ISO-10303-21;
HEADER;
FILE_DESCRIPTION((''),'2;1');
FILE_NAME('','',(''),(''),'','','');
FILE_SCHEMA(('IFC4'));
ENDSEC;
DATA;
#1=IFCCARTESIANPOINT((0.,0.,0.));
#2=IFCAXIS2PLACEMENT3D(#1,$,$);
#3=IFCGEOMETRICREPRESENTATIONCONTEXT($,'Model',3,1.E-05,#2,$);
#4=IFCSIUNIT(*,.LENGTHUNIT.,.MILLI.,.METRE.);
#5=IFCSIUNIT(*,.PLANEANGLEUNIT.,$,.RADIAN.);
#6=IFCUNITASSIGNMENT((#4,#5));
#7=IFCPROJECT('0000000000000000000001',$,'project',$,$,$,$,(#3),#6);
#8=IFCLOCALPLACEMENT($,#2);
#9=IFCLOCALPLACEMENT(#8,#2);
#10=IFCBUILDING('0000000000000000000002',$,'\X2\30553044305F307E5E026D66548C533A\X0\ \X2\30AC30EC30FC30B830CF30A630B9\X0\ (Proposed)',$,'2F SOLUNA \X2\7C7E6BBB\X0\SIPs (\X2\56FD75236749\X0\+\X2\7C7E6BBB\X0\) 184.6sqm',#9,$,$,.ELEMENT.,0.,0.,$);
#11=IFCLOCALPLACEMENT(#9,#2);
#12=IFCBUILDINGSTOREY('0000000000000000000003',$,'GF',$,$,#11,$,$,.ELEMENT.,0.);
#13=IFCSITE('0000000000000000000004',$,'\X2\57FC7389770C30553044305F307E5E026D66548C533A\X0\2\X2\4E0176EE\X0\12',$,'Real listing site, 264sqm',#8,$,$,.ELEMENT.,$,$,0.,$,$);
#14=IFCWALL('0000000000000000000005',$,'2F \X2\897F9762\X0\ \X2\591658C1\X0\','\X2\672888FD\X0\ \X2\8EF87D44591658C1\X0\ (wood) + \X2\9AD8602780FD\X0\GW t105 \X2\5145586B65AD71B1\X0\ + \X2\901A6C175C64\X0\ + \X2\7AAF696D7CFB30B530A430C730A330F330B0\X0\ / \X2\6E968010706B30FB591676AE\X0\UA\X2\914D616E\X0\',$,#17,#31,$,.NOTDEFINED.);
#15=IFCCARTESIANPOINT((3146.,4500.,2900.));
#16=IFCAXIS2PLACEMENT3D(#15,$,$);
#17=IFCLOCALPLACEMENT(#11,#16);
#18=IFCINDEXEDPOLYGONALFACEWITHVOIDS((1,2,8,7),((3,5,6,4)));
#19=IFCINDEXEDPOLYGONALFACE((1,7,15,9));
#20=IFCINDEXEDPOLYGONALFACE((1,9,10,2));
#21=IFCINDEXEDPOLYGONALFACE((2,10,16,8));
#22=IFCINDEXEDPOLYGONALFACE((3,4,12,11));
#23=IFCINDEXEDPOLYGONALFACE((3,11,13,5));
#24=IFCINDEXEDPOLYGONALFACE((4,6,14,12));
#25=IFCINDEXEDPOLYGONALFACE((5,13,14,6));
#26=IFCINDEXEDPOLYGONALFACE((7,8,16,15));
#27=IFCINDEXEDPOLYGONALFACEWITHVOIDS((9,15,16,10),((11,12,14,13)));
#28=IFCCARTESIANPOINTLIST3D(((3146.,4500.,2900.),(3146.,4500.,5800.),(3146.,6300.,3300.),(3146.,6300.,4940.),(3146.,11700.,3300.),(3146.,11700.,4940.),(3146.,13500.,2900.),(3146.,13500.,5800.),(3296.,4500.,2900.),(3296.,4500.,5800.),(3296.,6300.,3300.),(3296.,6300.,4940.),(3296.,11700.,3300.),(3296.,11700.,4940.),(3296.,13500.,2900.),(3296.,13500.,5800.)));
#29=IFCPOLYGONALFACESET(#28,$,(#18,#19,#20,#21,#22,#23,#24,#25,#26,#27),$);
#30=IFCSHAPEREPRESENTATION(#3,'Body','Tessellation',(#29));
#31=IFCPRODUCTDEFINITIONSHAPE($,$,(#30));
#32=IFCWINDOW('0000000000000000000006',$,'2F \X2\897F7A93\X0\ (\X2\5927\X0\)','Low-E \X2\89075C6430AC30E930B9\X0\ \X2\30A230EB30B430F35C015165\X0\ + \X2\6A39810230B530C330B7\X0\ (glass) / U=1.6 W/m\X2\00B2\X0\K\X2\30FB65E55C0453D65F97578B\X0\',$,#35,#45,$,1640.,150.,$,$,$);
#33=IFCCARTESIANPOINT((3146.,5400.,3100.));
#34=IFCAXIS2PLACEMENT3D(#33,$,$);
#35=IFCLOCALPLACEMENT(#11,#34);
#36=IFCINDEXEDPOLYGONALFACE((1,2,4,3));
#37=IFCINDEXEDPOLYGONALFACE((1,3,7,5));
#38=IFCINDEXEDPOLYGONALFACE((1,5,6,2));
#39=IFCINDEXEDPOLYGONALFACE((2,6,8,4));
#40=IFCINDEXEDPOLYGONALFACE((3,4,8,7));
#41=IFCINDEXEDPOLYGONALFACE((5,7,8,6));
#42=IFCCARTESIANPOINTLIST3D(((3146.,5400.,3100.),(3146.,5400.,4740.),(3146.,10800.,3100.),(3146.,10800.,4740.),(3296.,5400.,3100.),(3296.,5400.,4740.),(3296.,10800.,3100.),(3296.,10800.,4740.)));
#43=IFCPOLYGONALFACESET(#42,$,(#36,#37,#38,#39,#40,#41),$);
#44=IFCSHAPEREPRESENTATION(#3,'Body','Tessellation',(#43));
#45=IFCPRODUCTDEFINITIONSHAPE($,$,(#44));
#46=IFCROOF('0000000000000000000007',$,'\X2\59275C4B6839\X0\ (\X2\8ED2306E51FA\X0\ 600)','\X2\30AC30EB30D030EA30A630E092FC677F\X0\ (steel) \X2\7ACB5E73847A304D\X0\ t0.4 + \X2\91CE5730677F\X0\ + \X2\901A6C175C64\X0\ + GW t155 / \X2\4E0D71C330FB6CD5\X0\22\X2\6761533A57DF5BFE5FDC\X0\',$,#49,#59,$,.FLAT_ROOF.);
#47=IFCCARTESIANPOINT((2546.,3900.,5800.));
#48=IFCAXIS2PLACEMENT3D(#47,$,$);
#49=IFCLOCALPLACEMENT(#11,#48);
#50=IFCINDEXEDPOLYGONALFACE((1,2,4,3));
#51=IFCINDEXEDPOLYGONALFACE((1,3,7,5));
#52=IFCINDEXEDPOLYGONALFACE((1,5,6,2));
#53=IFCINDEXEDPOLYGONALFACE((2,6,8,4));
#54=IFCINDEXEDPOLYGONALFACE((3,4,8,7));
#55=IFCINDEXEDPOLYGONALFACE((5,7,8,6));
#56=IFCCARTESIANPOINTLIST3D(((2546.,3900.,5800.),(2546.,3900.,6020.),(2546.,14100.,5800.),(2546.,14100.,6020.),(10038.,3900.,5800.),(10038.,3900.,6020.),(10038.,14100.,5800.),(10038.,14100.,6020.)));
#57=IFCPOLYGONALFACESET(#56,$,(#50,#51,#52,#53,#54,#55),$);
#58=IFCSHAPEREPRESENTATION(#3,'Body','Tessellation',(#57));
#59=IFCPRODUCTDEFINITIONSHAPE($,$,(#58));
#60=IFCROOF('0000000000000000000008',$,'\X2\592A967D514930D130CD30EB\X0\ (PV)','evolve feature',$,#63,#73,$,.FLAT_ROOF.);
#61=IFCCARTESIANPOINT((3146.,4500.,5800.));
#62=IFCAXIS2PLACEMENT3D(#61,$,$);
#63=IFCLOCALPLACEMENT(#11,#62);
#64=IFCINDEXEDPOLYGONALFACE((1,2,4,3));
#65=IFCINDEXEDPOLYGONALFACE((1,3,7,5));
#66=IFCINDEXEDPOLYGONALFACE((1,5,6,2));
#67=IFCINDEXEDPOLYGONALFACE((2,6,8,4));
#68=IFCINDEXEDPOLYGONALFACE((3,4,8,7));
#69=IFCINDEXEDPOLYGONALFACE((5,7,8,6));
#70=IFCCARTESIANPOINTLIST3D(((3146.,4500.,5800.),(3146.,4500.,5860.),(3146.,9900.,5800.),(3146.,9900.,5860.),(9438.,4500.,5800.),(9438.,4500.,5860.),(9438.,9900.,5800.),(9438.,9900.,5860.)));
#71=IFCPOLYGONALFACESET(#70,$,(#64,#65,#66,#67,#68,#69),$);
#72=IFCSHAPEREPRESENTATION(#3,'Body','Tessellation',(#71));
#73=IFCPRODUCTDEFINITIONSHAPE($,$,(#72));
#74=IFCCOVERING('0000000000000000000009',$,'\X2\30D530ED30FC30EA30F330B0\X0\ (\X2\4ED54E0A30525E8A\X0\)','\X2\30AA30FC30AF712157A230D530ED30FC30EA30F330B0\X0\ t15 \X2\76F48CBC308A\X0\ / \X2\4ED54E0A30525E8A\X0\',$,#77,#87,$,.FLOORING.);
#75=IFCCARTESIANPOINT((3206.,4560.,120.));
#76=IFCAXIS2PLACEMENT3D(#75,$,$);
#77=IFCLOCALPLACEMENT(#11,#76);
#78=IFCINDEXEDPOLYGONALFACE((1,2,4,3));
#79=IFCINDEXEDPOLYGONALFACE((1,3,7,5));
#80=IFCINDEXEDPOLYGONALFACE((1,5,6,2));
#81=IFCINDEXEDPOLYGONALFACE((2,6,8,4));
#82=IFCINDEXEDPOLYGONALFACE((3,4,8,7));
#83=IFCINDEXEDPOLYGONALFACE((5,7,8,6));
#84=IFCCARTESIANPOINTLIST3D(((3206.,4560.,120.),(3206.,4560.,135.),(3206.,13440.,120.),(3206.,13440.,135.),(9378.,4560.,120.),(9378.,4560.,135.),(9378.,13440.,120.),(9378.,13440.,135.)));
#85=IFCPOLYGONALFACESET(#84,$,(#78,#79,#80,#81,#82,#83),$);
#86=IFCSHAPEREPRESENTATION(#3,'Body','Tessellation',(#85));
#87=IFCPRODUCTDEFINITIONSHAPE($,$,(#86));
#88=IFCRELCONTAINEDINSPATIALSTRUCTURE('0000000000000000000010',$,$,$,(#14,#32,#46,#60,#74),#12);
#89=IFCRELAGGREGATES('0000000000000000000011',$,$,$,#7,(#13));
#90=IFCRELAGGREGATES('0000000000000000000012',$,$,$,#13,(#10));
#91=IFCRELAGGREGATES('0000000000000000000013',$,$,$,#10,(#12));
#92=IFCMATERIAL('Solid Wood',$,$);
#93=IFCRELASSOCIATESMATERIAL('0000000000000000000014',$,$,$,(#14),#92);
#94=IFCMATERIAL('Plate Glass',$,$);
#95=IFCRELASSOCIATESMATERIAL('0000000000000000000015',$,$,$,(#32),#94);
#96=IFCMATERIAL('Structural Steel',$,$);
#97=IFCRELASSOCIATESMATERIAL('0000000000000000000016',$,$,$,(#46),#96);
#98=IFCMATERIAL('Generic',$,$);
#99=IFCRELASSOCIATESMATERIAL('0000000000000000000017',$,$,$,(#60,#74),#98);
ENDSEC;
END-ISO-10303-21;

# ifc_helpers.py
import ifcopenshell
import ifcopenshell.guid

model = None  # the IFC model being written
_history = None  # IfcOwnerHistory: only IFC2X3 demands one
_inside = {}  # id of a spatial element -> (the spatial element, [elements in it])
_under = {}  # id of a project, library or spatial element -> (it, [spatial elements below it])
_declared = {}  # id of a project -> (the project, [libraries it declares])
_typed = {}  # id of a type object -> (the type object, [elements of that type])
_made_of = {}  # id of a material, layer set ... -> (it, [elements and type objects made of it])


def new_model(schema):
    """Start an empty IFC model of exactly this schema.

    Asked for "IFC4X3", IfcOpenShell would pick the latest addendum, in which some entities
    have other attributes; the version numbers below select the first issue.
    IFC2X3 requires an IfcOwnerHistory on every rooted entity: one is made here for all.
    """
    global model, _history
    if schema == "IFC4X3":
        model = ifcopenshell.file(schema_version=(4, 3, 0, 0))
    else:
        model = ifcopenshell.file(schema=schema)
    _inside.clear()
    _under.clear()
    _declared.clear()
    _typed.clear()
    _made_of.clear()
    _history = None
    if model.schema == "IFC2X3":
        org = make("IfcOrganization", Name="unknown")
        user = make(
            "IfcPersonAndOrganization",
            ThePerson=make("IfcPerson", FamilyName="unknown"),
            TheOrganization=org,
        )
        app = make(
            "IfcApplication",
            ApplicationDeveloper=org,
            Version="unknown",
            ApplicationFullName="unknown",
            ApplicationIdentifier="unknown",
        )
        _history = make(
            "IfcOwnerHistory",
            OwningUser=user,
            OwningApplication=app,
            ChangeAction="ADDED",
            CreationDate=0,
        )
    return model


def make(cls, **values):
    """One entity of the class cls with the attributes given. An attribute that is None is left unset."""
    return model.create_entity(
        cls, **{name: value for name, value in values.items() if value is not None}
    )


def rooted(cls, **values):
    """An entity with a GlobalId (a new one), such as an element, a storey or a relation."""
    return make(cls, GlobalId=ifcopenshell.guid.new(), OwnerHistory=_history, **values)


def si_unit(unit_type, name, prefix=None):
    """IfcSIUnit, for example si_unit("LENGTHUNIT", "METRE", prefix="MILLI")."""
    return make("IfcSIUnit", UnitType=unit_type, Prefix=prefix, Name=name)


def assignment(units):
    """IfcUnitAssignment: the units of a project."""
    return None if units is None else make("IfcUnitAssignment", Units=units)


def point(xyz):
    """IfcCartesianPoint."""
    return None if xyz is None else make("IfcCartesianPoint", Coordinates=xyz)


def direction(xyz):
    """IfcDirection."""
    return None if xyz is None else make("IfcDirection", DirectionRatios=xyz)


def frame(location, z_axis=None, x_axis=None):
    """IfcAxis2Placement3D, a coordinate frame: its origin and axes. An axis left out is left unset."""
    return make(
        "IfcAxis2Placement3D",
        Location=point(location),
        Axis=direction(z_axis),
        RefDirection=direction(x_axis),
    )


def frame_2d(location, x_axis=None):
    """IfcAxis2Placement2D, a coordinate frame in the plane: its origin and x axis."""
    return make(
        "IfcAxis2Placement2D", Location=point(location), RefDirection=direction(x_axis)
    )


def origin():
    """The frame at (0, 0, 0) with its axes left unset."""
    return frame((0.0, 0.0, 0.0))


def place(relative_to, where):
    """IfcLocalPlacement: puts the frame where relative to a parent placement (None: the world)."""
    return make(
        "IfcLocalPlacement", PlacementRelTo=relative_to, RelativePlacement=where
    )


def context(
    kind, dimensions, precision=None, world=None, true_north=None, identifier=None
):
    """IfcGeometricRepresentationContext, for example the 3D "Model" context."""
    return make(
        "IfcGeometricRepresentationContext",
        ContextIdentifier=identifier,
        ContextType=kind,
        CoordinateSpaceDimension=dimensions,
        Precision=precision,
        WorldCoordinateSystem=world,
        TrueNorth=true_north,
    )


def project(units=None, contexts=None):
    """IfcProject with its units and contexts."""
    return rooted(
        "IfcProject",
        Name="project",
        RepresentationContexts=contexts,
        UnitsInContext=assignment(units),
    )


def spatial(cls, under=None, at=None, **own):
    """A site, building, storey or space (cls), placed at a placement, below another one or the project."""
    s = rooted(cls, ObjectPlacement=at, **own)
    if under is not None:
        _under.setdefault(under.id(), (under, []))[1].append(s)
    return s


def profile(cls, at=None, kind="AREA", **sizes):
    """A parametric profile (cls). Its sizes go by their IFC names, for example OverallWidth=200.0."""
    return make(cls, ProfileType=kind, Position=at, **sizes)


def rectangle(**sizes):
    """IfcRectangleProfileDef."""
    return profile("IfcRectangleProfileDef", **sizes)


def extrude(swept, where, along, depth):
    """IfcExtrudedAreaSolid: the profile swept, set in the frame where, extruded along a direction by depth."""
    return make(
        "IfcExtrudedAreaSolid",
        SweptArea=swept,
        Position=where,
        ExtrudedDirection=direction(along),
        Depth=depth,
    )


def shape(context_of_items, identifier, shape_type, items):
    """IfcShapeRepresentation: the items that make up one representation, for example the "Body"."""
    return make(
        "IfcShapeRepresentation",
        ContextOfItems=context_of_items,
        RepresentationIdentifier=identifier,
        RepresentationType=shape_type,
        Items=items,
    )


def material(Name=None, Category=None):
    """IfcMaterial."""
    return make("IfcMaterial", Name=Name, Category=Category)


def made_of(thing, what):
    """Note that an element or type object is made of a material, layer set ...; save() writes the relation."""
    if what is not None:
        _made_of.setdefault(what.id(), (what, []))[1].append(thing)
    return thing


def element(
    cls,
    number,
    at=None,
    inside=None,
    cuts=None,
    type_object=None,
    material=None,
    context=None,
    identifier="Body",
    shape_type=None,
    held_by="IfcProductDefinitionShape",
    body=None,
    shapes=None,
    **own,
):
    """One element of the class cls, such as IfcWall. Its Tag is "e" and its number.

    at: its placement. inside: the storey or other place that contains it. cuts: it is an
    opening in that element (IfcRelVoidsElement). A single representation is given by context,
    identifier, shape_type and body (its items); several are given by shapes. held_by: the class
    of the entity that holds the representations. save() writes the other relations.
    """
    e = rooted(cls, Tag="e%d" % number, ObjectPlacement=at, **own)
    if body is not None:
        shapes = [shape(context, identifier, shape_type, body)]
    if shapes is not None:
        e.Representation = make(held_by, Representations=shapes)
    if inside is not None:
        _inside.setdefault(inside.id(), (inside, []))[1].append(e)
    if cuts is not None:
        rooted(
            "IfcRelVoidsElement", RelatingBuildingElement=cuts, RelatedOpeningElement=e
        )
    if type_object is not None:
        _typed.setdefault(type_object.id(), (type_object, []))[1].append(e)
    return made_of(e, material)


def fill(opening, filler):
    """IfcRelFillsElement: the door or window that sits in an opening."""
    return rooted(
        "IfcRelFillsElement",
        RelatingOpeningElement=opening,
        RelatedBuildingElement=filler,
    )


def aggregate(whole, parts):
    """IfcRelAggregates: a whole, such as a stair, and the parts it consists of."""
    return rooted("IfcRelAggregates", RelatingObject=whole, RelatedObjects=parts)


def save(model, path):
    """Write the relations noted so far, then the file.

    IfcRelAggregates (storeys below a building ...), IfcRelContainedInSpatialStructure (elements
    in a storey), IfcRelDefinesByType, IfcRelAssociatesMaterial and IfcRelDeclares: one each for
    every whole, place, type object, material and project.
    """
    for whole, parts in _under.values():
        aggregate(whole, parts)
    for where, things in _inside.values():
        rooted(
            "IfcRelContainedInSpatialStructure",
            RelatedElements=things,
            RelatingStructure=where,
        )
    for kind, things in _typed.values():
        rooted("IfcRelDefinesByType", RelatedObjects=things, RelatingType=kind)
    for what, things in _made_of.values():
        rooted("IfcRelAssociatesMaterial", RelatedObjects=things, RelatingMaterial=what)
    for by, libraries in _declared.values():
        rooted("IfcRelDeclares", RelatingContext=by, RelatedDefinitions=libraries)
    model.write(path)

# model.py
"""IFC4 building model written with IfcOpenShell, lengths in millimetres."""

from ifc_helpers import new_model, si_unit, frame, frame_2d, origin, place, context, project, spatial, rectangle, extrude, material, element, fill, save


model = new_model("IFC4")

# Units and contexts
model_context = context("Model", 3, precision=1e-05, world=origin())
ifc_project = project(units=[si_unit("LENGTHUNIT", "METRE", prefix="MILLI"), si_unit("PLANEANGLEUNIT", "RADIAN")], contexts=[model_context])

# Site, building, storey
site_placement = place(None, origin())
site = spatial("IfcSite", under=ifc_project, at=site_placement, Name="埼玉県さいたま市浦和区2丁目12", ObjectType="Real listing site, 264sqm", CompositionType="ELEMENT", RefElevation=0.0)
building_placement = place(site_placement, origin())
building = spatial("IfcBuilding", under=site, at=building_placement, Name="さいたま市浦和区 ガレージハウス (Proposed)", ObjectType="2F SOLUNA 籾殻SIPs (国産杉+籾殻) 184.6sqm", CompositionType="ELEMENT", ElevationOfRefHeight=0.0, ElevationOfTerrain=0.0)
storey_placement = place(building_placement, origin())
storey = spatial("IfcBuildingStorey", under=building, at=storey_placement, Name="GF", CompositionType="ELEMENT", Elevation=0.0)

# Shared definitions
ifc_material_1 = material(Name="Solid Wood")
ifc_material_2 = material(Name="Generic")

# Shared definitions
ifc_material_3 = material(Name="Plate Glass")

# Wall, opening, window
wall_1_placement = place(storey_placement, frame((3146.0, 4500.0, 2900.0)))
wall_1 = element("IfcWall", 1, at=wall_1_placement, inside=storey, material=ifc_material_1, Name="2F 西面 外壁", Description="木製 軸組外壁 (wood) + 高性能GW t105 充填断熱 + 通気層 + 窯業系サイディング / 準耐火・外皮UA配慮", PredefinedType="NOTDEFINED", context=model_context, shape_type="SweptSolid", body=[
    extrude(rectangle(XDim=150.0, YDim=9000.0, at=frame_2d((75.0, 4500.0))), frame((3146.0, 4500.0, 2900.0)), (0.0, 0.0, 1.0), 2900.0),
])
opening_1_placement = place(storey_placement, frame((3146.0, 5400.0, 3100.0)))
opening_1 = element("IfcOpeningElement", 2, at=opening_1_placement, cuts=wall_1, PredefinedType="NOTDEFINED", context=model_context, shape_type="SweptSolid", body=[
    extrude(rectangle(XDim=150.0, YDim=5400.0, at=frame_2d((75.0, 2700.0))), frame((3146.0, 5400.0, 3100.0)), (0.0, 0.0, 1.0), 1640.0),
])
window_1_placement = place(storey_placement, frame((3146.0, 5400.0, 3100.0)))
window_1 = element("IfcWindow", 3, at=window_1_placement, inside=storey, material=ifc_material_3, Name="2F 西窓 (大)", Description="Low-E 複層ガラス アルゴン封入 + 樹脂サッシ (glass) / U=1.6 W/m²K・日射取得型", OverallHeight=1640.0, OverallWidth=150.0, context=model_context, shape_type="SweptSolid", body=[
    extrude(rectangle(XDim=150.0, YDim=5400.0, at=frame_2d((75.0, 2700.0))), frame((3146.0, 5400.0, 3100.0)), (0.0, 0.0, 1.0), 1640.0),
])
fill(opening_1, window_1)

# Roofs
ifc_material_4 = material(Name="Structural Steel")
roof_1_placement = place(storey_placement, frame((2546.0, 3900.0, 5800.0)))
element("IfcRoof", 4, at=roof_1_placement, inside=storey, material=ifc_material_4, Name="大屋根 (軒の出 600)", Description="ガルバリウム鋼板 (steel) 立平葺き t0.4 + 野地板 + 通気層 + GW t155 / 不燃・法22条区域対応", PredefinedType="FLAT_ROOF", context=model_context, shape_type="SweptSolid", body=[
    extrude(rectangle(XDim=7492.0, YDim=10200.0, at=frame_2d((3746.0, 5100.0))), frame((2546.0, 3900.0, 5800.0)), (0.0, 0.0, 1.0), 220.0),
])
roof_2_placement = place(storey_placement, frame((3146.0, 4500.0, 5800.0)))
element("IfcRoof", 5, at=roof_2_placement, inside=storey, material=ifc_material_2, Name="太陽光パネル (PV)", Description="evolve feature", PredefinedType="FLAT_ROOF", context=model_context, shape_type="SweptSolid", body=[
    extrude(rectangle(XDim=6292.0, YDim=5400.0, at=frame_2d((3146.0, 2700.0))), frame((3146.0, 4500.0, 5800.0)), (0.0, 0.0, 1.0), 60.0),
])

# Covering
covering_placement = place(storey_placement, frame((3206.0, 4560.0, 120.0)))
element("IfcCovering", 6, at=covering_placement, inside=storey, material=ifc_material_2, Name="フローリング (仕上げ床)", Description="オーク無垢フローリング t15 直貼り / 仕上げ床", PredefinedType="FLOORING", context=model_context, shape_type="SweptSolid", body=[
    extrude(rectangle(XDim=6172.0, YDim=8880.0, at=frame_2d((3086.0, 4440.0))), frame((3206.0, 4560.0, 120.0)), (0.0, 0.0, 1.0), 15.0),
])

save(model, "model.ifc")
